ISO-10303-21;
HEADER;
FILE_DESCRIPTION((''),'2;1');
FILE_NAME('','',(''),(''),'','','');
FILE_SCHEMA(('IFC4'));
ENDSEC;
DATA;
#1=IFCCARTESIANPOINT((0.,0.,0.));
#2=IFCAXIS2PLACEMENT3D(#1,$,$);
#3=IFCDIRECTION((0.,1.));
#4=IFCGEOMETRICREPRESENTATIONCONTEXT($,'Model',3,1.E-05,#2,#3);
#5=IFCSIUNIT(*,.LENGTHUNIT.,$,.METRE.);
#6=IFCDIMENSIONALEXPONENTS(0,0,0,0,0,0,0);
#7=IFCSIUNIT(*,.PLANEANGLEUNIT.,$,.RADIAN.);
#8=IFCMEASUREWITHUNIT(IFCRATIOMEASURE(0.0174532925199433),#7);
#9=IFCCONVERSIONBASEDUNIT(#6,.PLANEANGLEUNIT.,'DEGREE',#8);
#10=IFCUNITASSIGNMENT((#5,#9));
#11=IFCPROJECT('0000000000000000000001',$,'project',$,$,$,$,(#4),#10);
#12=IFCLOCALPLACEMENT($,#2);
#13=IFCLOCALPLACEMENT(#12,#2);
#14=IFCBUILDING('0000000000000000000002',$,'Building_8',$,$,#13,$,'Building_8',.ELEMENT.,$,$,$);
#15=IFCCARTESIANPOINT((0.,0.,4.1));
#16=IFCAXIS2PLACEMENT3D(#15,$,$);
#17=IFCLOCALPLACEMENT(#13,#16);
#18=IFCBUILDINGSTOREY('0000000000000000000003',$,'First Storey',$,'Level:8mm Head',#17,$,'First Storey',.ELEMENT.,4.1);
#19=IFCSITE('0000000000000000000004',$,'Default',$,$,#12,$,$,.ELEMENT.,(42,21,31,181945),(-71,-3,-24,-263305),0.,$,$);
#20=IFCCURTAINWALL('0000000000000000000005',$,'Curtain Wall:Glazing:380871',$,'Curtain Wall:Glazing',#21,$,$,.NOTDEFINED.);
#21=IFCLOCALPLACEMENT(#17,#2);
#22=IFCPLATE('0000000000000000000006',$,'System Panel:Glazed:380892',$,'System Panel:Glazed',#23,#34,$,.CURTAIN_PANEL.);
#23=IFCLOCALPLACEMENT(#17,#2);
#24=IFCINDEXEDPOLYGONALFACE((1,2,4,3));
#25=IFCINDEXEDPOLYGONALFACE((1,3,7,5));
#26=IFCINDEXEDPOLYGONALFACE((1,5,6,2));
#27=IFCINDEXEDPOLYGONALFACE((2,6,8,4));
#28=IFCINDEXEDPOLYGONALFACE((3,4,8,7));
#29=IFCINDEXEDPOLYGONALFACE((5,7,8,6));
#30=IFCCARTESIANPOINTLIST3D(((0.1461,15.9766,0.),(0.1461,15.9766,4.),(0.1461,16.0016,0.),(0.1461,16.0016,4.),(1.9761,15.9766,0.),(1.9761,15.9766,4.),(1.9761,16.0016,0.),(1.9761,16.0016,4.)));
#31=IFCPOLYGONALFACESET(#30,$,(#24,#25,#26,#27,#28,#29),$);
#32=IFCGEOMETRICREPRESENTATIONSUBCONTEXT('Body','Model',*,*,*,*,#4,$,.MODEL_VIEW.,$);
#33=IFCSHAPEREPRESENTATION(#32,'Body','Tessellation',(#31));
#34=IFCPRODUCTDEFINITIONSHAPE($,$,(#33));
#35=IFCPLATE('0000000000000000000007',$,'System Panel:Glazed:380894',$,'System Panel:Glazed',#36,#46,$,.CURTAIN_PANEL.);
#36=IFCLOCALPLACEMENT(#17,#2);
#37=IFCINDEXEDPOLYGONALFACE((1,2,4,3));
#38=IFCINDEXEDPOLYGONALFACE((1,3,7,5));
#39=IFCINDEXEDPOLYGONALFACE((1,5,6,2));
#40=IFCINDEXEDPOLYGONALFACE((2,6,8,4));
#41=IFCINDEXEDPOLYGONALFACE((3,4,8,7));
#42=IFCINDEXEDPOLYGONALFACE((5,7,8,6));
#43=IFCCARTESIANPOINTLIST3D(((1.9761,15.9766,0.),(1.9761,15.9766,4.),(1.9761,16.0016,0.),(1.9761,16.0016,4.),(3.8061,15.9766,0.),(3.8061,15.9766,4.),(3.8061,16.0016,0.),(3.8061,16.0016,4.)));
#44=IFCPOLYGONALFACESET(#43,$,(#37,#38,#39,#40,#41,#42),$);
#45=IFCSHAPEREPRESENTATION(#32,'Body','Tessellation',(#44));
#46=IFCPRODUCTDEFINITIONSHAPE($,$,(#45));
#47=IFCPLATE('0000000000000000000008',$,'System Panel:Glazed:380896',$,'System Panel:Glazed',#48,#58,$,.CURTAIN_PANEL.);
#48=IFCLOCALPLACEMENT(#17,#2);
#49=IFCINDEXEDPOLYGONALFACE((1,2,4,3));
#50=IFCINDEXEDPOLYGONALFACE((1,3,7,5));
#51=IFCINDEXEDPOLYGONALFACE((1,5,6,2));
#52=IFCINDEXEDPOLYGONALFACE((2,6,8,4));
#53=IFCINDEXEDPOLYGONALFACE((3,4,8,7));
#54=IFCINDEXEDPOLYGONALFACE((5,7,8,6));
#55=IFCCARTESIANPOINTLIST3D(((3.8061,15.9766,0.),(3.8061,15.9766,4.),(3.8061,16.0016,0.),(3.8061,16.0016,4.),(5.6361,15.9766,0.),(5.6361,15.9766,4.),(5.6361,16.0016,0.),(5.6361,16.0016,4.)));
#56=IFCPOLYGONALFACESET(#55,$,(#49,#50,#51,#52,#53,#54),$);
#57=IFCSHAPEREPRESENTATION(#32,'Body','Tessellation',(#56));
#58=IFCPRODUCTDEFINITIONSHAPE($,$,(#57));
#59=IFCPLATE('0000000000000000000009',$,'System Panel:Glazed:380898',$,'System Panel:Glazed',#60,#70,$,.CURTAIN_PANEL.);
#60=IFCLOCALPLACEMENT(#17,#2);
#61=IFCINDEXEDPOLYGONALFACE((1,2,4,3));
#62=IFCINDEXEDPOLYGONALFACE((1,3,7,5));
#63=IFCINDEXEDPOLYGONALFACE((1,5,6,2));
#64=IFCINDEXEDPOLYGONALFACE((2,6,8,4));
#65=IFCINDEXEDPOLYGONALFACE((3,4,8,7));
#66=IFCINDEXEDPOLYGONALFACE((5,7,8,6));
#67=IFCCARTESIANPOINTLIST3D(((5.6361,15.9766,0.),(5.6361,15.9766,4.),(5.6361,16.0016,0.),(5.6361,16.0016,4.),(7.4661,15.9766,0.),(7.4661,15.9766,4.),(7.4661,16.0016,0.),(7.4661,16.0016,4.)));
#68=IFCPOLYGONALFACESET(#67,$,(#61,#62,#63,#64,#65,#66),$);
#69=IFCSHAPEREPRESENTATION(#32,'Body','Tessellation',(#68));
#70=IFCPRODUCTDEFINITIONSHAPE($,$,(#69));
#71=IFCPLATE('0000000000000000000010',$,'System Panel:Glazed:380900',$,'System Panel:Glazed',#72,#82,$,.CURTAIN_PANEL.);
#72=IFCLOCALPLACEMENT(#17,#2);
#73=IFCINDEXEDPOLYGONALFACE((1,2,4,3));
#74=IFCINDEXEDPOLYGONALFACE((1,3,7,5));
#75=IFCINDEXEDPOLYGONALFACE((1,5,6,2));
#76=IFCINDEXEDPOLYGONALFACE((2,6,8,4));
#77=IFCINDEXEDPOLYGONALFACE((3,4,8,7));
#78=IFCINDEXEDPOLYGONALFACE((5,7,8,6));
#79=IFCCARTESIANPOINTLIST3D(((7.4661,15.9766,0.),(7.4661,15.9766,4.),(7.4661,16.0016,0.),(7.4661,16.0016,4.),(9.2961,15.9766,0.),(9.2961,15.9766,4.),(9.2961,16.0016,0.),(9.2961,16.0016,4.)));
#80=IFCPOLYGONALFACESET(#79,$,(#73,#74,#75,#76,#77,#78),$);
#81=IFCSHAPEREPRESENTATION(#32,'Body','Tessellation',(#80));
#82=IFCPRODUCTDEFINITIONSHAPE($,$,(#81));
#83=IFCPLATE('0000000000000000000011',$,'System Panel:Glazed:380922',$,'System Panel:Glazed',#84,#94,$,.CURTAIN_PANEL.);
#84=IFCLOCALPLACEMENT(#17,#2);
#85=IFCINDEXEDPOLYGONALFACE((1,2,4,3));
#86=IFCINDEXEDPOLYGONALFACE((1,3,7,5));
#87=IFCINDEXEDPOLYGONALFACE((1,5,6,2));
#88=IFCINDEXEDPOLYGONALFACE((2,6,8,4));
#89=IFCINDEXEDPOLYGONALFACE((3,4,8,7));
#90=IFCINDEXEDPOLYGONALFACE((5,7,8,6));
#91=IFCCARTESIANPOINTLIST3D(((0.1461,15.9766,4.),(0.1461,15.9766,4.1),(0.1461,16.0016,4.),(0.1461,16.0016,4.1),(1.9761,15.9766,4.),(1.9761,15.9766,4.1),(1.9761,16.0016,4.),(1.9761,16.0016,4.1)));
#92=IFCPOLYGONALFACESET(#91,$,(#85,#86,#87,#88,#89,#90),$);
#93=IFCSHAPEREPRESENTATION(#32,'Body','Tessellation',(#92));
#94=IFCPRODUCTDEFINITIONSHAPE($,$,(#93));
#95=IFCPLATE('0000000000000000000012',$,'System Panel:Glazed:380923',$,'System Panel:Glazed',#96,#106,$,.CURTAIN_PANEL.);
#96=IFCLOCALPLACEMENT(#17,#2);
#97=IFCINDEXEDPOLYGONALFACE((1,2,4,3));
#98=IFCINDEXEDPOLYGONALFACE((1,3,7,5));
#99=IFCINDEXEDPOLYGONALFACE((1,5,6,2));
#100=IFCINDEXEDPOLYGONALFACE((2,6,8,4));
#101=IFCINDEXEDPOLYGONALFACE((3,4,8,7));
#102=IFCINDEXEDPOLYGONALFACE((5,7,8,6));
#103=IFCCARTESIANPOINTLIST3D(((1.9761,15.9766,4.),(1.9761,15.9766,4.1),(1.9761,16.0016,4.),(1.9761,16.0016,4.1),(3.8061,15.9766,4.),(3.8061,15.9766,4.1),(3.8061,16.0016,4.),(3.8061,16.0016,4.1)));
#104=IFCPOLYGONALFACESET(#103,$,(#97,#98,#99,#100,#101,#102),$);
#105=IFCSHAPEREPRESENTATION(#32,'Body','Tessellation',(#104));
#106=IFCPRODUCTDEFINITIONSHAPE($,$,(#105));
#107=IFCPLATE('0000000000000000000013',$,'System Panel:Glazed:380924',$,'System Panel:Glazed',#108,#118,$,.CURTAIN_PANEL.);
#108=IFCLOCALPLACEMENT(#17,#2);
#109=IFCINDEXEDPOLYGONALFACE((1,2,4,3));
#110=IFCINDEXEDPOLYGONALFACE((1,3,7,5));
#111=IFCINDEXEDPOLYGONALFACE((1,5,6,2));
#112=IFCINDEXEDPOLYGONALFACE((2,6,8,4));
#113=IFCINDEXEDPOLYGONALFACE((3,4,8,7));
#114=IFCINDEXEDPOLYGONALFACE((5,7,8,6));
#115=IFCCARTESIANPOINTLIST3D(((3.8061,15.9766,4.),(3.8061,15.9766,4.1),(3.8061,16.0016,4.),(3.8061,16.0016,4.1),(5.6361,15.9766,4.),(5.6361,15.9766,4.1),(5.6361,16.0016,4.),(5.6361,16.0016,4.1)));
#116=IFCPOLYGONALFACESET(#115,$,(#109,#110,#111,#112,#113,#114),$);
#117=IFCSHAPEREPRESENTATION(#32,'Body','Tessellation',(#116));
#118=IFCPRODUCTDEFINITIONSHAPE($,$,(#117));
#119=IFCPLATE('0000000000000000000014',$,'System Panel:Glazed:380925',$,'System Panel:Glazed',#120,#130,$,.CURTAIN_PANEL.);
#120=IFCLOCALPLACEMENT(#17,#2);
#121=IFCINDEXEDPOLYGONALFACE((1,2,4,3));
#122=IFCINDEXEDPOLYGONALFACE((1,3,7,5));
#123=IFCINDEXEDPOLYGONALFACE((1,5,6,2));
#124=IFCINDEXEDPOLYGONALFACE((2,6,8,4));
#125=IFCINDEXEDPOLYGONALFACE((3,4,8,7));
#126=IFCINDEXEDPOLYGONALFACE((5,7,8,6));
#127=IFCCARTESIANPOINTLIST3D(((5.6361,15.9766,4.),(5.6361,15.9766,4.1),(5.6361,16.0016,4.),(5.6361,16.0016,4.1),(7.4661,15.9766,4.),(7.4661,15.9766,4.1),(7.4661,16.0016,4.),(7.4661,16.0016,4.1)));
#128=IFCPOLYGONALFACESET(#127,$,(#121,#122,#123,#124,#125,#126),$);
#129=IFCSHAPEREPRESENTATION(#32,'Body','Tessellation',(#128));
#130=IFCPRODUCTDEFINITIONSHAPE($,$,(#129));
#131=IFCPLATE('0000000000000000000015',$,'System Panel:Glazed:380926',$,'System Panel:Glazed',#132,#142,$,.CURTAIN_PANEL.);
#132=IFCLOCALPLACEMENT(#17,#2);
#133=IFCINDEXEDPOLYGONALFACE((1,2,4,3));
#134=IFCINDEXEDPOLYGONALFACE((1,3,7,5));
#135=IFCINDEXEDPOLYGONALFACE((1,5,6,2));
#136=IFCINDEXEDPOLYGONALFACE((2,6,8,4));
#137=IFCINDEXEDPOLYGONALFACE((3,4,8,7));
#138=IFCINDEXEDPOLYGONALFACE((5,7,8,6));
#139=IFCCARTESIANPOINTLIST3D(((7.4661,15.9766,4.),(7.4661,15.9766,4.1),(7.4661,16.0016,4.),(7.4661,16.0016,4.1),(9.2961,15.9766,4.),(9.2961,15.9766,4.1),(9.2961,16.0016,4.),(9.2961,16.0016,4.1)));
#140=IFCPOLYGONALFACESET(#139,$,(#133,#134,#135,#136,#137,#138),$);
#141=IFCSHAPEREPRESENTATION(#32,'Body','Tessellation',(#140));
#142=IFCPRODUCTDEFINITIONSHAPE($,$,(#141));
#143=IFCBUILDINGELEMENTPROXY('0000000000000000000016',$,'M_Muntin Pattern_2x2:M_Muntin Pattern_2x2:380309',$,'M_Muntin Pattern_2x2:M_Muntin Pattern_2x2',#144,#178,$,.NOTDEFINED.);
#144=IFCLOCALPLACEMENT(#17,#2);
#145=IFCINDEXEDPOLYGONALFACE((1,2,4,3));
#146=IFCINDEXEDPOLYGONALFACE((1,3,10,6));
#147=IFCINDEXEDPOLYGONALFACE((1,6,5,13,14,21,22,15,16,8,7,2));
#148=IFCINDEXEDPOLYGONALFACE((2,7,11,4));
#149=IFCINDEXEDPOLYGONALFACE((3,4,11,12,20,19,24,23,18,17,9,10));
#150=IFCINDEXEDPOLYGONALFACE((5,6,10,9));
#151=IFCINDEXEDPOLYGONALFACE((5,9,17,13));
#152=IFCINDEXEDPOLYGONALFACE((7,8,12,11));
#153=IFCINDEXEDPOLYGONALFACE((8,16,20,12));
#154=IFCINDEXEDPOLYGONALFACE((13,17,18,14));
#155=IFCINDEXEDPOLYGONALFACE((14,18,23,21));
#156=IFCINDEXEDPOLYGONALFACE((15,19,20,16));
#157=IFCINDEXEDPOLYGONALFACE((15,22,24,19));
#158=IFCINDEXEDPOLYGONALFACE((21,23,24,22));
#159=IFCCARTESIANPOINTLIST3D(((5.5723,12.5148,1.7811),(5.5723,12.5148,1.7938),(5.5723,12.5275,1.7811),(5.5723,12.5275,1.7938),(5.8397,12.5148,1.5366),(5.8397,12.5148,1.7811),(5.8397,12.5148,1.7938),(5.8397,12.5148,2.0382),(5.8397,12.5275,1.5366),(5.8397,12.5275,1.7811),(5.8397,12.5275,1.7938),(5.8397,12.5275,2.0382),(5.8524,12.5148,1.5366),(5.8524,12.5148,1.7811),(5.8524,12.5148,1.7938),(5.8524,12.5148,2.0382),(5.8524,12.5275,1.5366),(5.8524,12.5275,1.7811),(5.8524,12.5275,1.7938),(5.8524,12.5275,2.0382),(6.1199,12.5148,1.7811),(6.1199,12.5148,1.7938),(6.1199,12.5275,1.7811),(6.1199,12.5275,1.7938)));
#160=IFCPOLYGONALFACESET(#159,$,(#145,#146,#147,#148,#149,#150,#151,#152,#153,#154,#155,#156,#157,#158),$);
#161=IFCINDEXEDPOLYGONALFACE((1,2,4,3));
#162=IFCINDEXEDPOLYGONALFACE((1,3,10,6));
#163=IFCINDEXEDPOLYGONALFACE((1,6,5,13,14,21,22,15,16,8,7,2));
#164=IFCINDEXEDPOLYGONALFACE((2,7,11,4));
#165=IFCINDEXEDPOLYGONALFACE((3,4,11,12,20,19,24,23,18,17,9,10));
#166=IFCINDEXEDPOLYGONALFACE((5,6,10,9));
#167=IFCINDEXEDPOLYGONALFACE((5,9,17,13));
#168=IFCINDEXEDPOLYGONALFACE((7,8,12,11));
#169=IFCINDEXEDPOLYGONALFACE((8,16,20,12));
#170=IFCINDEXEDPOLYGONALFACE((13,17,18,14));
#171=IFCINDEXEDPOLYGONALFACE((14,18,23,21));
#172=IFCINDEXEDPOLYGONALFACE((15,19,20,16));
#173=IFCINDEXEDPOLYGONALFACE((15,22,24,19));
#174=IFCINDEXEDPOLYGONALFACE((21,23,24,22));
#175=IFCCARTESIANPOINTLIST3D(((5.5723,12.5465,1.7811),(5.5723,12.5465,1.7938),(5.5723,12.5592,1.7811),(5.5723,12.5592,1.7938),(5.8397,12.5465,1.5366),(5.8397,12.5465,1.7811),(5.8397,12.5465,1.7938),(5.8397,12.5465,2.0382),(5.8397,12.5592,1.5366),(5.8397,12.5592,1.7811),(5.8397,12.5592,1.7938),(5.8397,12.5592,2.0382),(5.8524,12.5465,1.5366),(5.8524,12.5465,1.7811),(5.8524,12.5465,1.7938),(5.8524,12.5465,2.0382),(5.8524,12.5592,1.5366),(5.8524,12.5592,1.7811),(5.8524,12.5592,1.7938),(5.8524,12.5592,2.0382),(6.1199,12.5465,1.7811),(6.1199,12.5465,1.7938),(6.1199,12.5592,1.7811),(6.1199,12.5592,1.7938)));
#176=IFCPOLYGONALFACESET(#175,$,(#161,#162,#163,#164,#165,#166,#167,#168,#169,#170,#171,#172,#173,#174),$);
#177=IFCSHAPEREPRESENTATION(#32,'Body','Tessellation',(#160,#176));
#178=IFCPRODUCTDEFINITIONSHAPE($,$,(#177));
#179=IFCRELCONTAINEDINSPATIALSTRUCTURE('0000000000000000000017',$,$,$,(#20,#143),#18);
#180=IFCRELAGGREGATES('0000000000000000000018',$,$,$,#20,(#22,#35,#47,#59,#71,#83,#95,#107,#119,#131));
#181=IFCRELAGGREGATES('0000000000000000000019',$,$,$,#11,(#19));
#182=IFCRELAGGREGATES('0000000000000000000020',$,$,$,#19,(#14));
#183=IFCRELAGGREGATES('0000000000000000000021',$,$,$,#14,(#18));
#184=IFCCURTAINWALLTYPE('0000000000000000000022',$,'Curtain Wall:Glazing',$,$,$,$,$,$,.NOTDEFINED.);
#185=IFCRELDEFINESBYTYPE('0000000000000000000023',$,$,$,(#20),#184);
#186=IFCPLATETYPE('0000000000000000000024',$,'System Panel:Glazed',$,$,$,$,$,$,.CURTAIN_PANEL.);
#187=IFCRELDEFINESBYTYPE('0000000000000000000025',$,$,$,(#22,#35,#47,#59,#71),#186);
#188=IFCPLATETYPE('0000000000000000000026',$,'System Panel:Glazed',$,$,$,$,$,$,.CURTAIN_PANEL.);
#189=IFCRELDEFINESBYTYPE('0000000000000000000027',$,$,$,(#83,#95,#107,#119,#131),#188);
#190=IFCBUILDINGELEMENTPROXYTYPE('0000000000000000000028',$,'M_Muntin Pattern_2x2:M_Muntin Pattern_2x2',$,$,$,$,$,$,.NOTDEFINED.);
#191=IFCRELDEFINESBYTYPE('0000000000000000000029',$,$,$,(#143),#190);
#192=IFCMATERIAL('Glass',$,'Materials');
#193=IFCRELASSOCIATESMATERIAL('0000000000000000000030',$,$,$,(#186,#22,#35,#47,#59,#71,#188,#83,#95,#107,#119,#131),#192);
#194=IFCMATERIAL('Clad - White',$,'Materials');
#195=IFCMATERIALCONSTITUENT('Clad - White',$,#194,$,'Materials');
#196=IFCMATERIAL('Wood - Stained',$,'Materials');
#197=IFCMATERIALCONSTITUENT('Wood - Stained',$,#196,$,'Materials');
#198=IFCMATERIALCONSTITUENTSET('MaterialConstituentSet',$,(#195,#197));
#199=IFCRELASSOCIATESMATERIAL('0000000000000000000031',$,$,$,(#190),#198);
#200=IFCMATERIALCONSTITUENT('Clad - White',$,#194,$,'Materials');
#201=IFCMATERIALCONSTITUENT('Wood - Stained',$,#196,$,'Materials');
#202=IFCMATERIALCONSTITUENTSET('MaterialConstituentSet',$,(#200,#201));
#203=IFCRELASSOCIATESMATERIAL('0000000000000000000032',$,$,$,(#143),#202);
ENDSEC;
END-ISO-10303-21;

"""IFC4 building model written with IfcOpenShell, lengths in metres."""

from ifc_helpers import new_model, entity, si_unit, converted_unit, direction, frame, origin, place, context, subcontext, project, spatial, indexed_curve, outline, extrude, source, transform, mapped, material, constituent, constituent_set, type_object, type_shapes, element, aggregate, save


model = new_model("IFC4")

# Units and contexts
model_context = context("Model", 3, precision=1e-05, world=origin(), true_north=direction((0.0, 1.0)))
body_context = subcontext(model_context, "Body", "Model", "MODEL_VIEW")
ifc_project = project(units=[si_unit("LENGTHUNIT", "METRE"), converted_unit("PLANEANGLEUNIT", "DEGREE", entity("IfcRatioMeasure", 0.0174532925199433), si_unit("PLANEANGLEUNIT", "RADIAN"), dimensions=[0, 0, 0, 0, 0, 0, 0])], contexts=[model_context])

# Site, building, storey
site_placement = place(None, origin())
site = spatial("IfcSite", under=ifc_project, at=site_placement, Name="Default", CompositionType="ELEMENT", RefLatitude=(42, 21, 31, 181945), RefLongitude=(-71, -3, -24, -263305), RefElevation=0.0)
building_placement = place(site_placement, origin())
building = spatial("IfcBuilding", under=site, at=building_placement, Name="Building_8", LongName="Building_8", CompositionType="ELEMENT")
storey_placement = place(building_placement, frame((0.0, 0.0, 4.1)))
storey = spatial("IfcBuildingStorey", under=building, at=storey_placement, Name="First Storey", ObjectType="Level:8mm Head", LongName="First Storey", CompositionType="ELEMENT", Elevation=4.1)

# Curtain wall, plates
curtain_wall_type = type_object("IfcCurtainWallType", Name="Curtain Wall:Glazing", PredefinedType="NOTDEFINED")
curtain_wall_placement = place(storey_placement, frame((0.0, 0.0, -4.1)))
curtain_wall = element("IfcCurtainWall", 1, at=curtain_wall_placement, inside=storey, type_object=curtain_wall_type, Name="Curtain Wall:Glazing:380871", ObjectType="Curtain Wall:Glazing", PredefinedType="NOTDEFINED")
ifc_material_1 = material(Name="Glass", Category="Materials")
plate_type_1 = type_object("IfcPlateType", Name="System Panel:Glazed", PredefinedType="CURTAIN_PANEL", material=ifc_material_1)
shared_shape_1 = source(origin(), body_context, "Body", "SweptSolid", [
    extrude(outline(indexed_curve([(-0.0125, -0.915), (0.0125, -0.915), (0.0125, 0.915), (-0.0125, 0.915), (-0.0125, -0.915)], self_intersect=False)), frame((0.0, 0.037, 0.0), z_axis=(0.0, 0.0, 1.0), x_axis=(0.0, 1.0, 0.0)), (0.0, 0.0, 1.0), 4.0),
])
type_shapes(plate_type_1, [shared_shape_1])
plate_1_placement = place(curtain_wall_placement, frame((1.0611, 15.9521, 4.1)))
plate_1 = element("IfcPlate", 2, at=plate_1_placement, type_object=plate_type_1, material=ifc_material_1, Name="System Panel:Glazed:380892", ObjectType="System Panel:Glazed", PredefinedType="CURTAIN_PANEL", context=body_context, shape_type="MappedRepresentation", body=[
    mapped(shared_shape_1, transform((0.0, 0.0, 0.0), scale=1.0)),
])
plate_2_placement = place(curtain_wall_placement, frame((2.8911, 15.9521, 4.1)))
plate_2 = element("IfcPlate", 3, at=plate_2_placement, type_object=plate_type_1, material=ifc_material_1, Name="System Panel:Glazed:380894", ObjectType="System Panel:Glazed", PredefinedType="CURTAIN_PANEL", context=body_context, shape_type="MappedRepresentation", body=[
    mapped(shared_shape_1, transform((0.0, 0.0, 0.0), scale=1.0)),
])
plate_3_placement = place(curtain_wall_placement, frame((4.7211, 15.9521, 4.1)))
plate_3 = element("IfcPlate", 4, at=plate_3_placement, type_object=plate_type_1, material=ifc_material_1, Name="System Panel:Glazed:380896", ObjectType="System Panel:Glazed", PredefinedType="CURTAIN_PANEL", context=body_context, shape_type="MappedRepresentation", body=[
    mapped(shared_shape_1, transform((0.0, 0.0, 0.0), scale=1.0)),
])
plate_4_placement = place(curtain_wall_placement, frame((6.5511, 15.9521, 4.1)))
plate_4 = element("IfcPlate", 5, at=plate_4_placement, type_object=plate_type_1, material=ifc_material_1, Name="System Panel:Glazed:380898", ObjectType="System Panel:Glazed", PredefinedType="CURTAIN_PANEL", context=body_context, shape_type="MappedRepresentation", body=[
    mapped(shared_shape_1, transform((0.0, 0.0, 0.0), scale=1.0)),
])
plate_5_placement = place(curtain_wall_placement, frame((8.3811, 15.9521, 4.1)))
plate_5 = element("IfcPlate", 6, at=plate_5_placement, type_object=plate_type_1, material=ifc_material_1, Name="System Panel:Glazed:380900", ObjectType="System Panel:Glazed", PredefinedType="CURTAIN_PANEL", context=body_context, shape_type="MappedRepresentation", body=[
    mapped(shared_shape_1, transform((0.0, 0.0, 0.0), scale=1.0)),
])
plate_type_2 = type_object("IfcPlateType", Name="System Panel:Glazed", PredefinedType="CURTAIN_PANEL", material=ifc_material_1)
shared_shape_2 = source(origin(), body_context, "Body", "SweptSolid", [
    extrude(outline(indexed_curve([(-0.0125, -0.915), (0.0125, -0.915), (0.0125, 0.915), (-0.0125, 0.915), (-0.0125, -0.915)], self_intersect=False)), frame((0.0, 0.037, 0.0), z_axis=(0.0, 0.0, 1.0), x_axis=(0.0, 1.0, 0.0)), (0.0, 0.0, 1.0), 0.1),
])
type_shapes(plate_type_2, [shared_shape_2])
plate_6_placement = place(curtain_wall_placement, frame((1.0611, 15.9521, 8.1)))
plate_6 = element("IfcPlate", 7, at=plate_6_placement, type_object=plate_type_2, material=ifc_material_1, Name="System Panel:Glazed:380922", ObjectType="System Panel:Glazed", PredefinedType="CURTAIN_PANEL", context=body_context, shape_type="MappedRepresentation", body=[
    mapped(shared_shape_2, transform((0.0, 0.0, 0.0), scale=1.0)),
])
plate_7_placement = place(curtain_wall_placement, frame((2.8911, 15.9521, 8.1)))
plate_7 = element("IfcPlate", 8, at=plate_7_placement, type_object=plate_type_2, material=ifc_material_1, Name="System Panel:Glazed:380923", ObjectType="System Panel:Glazed", PredefinedType="CURTAIN_PANEL", context=body_context, shape_type="MappedRepresentation", body=[
    mapped(shared_shape_2, transform((0.0, 0.0, 0.0), scale=1.0)),
])
plate_8_placement = place(curtain_wall_placement, frame((4.7211, 15.9521, 8.1)))
plate_8 = element("IfcPlate", 9, at=plate_8_placement, type_object=plate_type_2, material=ifc_material_1, Name="System Panel:Glazed:380924", ObjectType="System Panel:Glazed", PredefinedType="CURTAIN_PANEL", context=body_context, shape_type="MappedRepresentation", body=[
    mapped(shared_shape_2, transform((0.0, 0.0, 0.0), scale=1.0)),
])
plate_9_placement = place(curtain_wall_placement, frame((6.5511, 15.9521, 8.1)))
plate_9 = element("IfcPlate", 10, at=plate_9_placement, type_object=plate_type_2, material=ifc_material_1, Name="System Panel:Glazed:380925", ObjectType="System Panel:Glazed", PredefinedType="CURTAIN_PANEL", context=body_context, shape_type="MappedRepresentation", body=[
    mapped(shared_shape_2, transform((0.0, 0.0, 0.0), scale=1.0)),
])
plate_10_placement = place(curtain_wall_placement, frame((8.3811, 15.9521, 8.1)))
plate_10 = element("IfcPlate", 11, at=plate_10_placement, type_object=plate_type_2, material=ifc_material_1, Name="System Panel:Glazed:380926", ObjectType="System Panel:Glazed", PredefinedType="CURTAIN_PANEL", context=body_context, shape_type="MappedRepresentation", body=[
    mapped(shared_shape_2, transform((0.0, 0.0, 0.0), scale=1.0)),
])
aggregate(curtain_wall, [plate_1, plate_2, plate_3, plate_4, plate_5, plate_6, plate_7, plate_8, plate_9, plate_10])

# Building element proxy
ifc_material_2 = material(Name="Clad - White", Category="Materials")
ifc_constituent_1 = constituent(ifc_material_2, Name="Clad - White", Category="Materials")
ifc_material_3 = material(Name="Wood - Stained", Category="Materials")
ifc_constituent_2 = constituent(ifc_material_3, Name="Wood - Stained", Category="Materials")
ifc_constituent_set_1 = constituent_set(constituents=[ifc_constituent_1, ifc_constituent_2], Name="MaterialConstituentSet")
ifc_constituent_3 = constituent(ifc_material_2, Name="Clad - White", Category="Materials")
ifc_constituent_4 = constituent(ifc_material_3, Name="Wood - Stained", Category="Materials")
ifc_constituent_set_2 = constituent_set(constituents=[ifc_constituent_3, ifc_constituent_4], Name="MaterialConstituentSet")
building_element_proxy_type_1 = type_object("IfcBuildingElementProxyType", Name="M_Muntin Pattern_2x2:M_Muntin Pattern_2x2", PredefinedType="NOTDEFINED", material=ifc_constituent_set_2)
shared_shape_3 = source(origin(), body_context, "Body", "SweptSolid", [
    extrude(outline(indexed_curve([(0.0064, -0.0064), (0.2508, -0.0064), (0.2508, 0.0063), (0.0064, 0.0063), (0.0064, 0.2738), (-0.0063, 0.2738), (-0.0063, 0.0063), (-0.2508, 0.0063), (-0.2508, -0.0064), (-0.0063, -0.0064), (-0.0063, -0.2738), (0.0064, -0.2738), (0.0064, -0.0064)], self_intersect=False)), frame((0.0, -0.0222, 0.2508), z_axis=(0.0, 1.0, 0.0), x_axis=(0.0, 0.0, 1.0)), (0.0, 0.0, 1.0), 0.0127),
    extrude(outline(indexed_curve([(0.0064, -0.0064), (0.2508, -0.0064), (0.2508, 0.0063), (0.0064, 0.0063), (0.0064, 0.2738), (-0.0063, 0.2738), (-0.0063, 0.0063), (-0.2508, 0.0063), (-0.2508, -0.0064), (-0.0063, -0.0064), (-0.0063, -0.2738), (0.0064, -0.2738), (0.0064, -0.0064)], self_intersect=False)), frame((0.0, 0.0095, 0.2508), z_axis=(0.0, 1.0, 0.0), x_axis=(0.0, 0.0, 1.0)), (0.0, 0.0, 1.0), 0.0127),
])
type_shapes(building_element_proxy_type_1, [shared_shape_3])
proxy_1_placement = place(storey_placement, frame((5.8461, 12.537, 1.5366)))
element("IfcBuildingElementProxy", 12, at=proxy_1_placement, inside=storey, type_object=building_element_proxy_type_1, material=ifc_constituent_set_1, Name="M_Muntin Pattern_2x2:M_Muntin Pattern_2x2:380309", ObjectType="M_Muntin Pattern_2x2:M_Muntin Pattern_2x2", PredefinedType="NOTDEFINED", context=body_context, shape_type="MappedRepresentation", body=[
    mapped(shared_shape_3, transform((0.0, 0.0, 0.0), scale=1.0)),
])

save(model, "model.ifc")
